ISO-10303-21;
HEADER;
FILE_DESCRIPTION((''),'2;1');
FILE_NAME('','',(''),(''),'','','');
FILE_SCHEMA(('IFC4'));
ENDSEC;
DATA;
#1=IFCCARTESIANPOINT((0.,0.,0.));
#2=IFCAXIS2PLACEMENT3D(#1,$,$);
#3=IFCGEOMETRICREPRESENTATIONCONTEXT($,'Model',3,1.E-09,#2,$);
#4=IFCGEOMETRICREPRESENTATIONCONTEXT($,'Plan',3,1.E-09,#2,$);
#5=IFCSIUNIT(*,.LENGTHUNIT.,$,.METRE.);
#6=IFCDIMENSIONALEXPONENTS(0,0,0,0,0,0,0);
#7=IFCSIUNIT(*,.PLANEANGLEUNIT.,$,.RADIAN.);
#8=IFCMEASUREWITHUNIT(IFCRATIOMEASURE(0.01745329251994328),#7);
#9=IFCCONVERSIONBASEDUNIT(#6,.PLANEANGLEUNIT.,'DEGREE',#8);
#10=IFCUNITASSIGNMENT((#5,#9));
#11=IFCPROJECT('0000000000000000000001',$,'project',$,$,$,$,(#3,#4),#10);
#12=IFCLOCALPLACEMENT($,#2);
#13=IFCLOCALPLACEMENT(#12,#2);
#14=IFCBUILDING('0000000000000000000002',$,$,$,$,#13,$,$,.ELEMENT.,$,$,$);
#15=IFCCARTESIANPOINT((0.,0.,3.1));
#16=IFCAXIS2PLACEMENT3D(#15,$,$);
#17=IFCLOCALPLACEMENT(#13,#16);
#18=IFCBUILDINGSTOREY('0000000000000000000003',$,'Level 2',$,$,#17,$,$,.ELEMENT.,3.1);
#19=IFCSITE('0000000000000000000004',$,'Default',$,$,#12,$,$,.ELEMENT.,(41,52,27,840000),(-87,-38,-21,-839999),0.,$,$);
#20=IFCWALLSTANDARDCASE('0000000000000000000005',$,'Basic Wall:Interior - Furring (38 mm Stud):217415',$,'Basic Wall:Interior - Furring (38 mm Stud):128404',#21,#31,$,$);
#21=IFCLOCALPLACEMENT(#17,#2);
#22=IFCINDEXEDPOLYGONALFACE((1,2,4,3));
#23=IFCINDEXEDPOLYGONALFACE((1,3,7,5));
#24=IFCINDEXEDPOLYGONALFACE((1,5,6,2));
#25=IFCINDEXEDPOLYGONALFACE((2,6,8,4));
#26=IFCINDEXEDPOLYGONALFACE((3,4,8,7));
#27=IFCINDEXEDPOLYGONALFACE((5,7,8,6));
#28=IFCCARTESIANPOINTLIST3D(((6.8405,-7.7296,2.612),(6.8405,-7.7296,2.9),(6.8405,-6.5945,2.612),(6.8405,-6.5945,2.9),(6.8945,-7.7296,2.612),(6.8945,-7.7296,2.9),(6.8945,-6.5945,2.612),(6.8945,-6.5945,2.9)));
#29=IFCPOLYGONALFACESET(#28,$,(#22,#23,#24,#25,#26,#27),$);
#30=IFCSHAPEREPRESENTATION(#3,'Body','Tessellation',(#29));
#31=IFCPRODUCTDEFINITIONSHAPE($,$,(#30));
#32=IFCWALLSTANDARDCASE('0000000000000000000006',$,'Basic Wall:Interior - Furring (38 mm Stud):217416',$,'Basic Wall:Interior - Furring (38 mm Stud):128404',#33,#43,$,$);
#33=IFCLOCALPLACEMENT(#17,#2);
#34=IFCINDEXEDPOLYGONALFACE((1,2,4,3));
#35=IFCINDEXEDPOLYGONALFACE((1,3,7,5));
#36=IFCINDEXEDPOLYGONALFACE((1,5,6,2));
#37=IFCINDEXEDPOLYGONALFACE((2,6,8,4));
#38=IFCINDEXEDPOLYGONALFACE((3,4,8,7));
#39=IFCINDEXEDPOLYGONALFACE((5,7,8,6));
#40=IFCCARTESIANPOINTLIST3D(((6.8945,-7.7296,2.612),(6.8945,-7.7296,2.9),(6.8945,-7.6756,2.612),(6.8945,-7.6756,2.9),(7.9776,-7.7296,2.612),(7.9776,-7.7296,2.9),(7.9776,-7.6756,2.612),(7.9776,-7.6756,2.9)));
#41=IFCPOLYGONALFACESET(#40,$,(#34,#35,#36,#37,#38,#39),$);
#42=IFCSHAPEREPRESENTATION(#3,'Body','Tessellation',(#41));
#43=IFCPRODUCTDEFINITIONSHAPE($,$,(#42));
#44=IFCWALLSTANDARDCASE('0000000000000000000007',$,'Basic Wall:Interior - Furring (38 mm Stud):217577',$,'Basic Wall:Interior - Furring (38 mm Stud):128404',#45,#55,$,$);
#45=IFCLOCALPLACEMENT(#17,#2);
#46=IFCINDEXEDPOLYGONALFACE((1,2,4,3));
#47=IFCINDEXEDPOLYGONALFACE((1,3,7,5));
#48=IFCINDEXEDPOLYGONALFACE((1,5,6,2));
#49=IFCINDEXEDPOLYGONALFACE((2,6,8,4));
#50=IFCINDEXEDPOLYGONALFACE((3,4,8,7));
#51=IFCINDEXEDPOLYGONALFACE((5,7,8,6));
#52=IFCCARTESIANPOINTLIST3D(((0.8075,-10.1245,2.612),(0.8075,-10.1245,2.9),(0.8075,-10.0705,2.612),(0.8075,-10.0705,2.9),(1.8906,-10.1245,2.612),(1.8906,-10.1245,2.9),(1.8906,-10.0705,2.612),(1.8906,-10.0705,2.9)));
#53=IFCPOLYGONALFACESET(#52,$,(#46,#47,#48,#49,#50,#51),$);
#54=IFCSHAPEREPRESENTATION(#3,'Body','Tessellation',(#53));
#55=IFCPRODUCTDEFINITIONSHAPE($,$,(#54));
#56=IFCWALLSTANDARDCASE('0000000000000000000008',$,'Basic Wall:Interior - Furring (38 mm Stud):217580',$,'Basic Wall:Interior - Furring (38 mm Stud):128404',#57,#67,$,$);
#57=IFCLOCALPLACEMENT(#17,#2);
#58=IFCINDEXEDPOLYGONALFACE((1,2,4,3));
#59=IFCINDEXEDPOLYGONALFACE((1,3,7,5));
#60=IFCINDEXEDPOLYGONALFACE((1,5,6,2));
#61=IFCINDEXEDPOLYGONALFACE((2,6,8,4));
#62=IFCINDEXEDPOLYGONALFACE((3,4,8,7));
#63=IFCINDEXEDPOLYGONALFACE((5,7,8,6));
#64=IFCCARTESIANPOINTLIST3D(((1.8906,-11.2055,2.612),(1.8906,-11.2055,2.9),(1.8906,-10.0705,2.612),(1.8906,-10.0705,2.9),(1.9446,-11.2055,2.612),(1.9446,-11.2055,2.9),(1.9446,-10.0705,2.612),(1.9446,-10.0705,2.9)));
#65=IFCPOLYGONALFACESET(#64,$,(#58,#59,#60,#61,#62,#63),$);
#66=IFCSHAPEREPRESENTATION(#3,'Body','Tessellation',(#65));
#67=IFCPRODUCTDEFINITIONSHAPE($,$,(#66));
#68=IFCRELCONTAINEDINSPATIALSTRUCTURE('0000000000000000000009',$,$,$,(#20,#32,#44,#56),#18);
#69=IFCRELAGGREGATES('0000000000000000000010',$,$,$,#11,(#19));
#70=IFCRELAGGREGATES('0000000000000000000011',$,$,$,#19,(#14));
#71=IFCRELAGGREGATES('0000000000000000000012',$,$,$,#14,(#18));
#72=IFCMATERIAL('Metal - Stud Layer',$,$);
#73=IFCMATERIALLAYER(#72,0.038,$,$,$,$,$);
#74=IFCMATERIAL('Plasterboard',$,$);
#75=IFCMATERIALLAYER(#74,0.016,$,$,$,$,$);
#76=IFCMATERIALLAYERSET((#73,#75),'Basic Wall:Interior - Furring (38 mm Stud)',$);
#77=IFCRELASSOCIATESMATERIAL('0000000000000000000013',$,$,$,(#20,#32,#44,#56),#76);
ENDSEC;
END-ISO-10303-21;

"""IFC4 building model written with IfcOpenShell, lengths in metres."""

from ifc_helpers import new_model, entity, si_unit, converted_unit, frame, frame_2d, origin, place, context, project, spatial, rectangle, extrude, material, layer, layer_set, layer_usage, element, save


model = new_model("IFC4")

# Units and contexts
model_context = context("Model", 3, precision=1e-09, world=origin())
plan_context = context("Plan", 3, precision=1e-09, world=origin())
ifc_project = project(units=[si_unit("LENGTHUNIT", "METRE"), converted_unit("PLANEANGLEUNIT", "DEGREE", entity("IfcRatioMeasure", 0.01745329251994328), si_unit("PLANEANGLEUNIT", "RADIAN"), dimensions=[0, 0, 0, 0, 0, 0, 0])], contexts=[model_context, plan_context])

# Site, building, storey
site_placement = place(None, origin())
site = spatial("IfcSite", under=ifc_project, at=site_placement, Name="Default", CompositionType="ELEMENT", RefLatitude=(41, 52, 27, 840000), RefLongitude=(-87, -38, -21, -839999), RefElevation=0.0)
building_placement = place(site_placement, origin())
building = spatial("IfcBuilding", under=site, at=building_placement, CompositionType="ELEMENT")
storey_placement = place(building_placement, frame((0.0, 0.0, 3.1)))
storey = spatial("IfcBuildingStorey", under=building, at=storey_placement, Name="Level 2", CompositionType="ELEMENT", Elevation=3.1)

# Shared definitions
ifc_material_1 = material(Name="Plasterboard")
ifc_material_2 = material(Name="Metal - Stud Layer")

# Walls
ifc_layer_1 = layer(ifc_material_2, 0.038)
ifc_layer_2 = layer(ifc_material_1, 0.016)
ifc_layer_set_1 = layer_set([ifc_layer_1, ifc_layer_2], Name="Basic Wall:Interior - Furring (38 mm Stud)")
ifc_layer_usage_1 = layer_usage(ifc_layer_set_1, "AXIS2", "NEGATIVE", 0.027)
wall_1_placement = place(storey_placement, frame((6.8675, -7.7296, 2.612), z_axis=(0.0, 0.0, 1.0), x_axis=(0.0, 1.0, 0.0)))
element("IfcWallStandardCase", 1, at=wall_1_placement, inside=storey, material=ifc_layer_usage_1, Name="Basic Wall:Interior - Furring (38 mm Stud):217415", ObjectType="Basic Wall:Interior - Furring (38 mm Stud):128404", context=model_context, shape_type="SweptSolid", body=[
    extrude(rectangle(XDim=1.1351, YDim=0.054, at=frame_2d((0.5675, 0.0), x_axis=(-1.0, 0.0))), origin(), (0.0, 0.0, 1.0), 0.288),
])
ifc_layer_usage_2 = layer_usage(ifc_layer_set_1, "AXIS2", "NEGATIVE", 0.027)
wall_2_placement = place(storey_placement, frame((7.9776, -7.7026, 2.612), z_axis=(0.0, 0.0, 1.0), x_axis=(-1.0, 0.0, 0.0)))
element("IfcWallStandardCase", 2, at=wall_2_placement, inside=storey, material=ifc_layer_usage_2, Name="Basic Wall:Interior - Furring (38 mm Stud):217416", ObjectType="Basic Wall:Interior - Furring (38 mm Stud):128404", context=model_context, shape_type="SweptSolid", body=[
    extrude(rectangle(XDim=1.0831, YDim=0.054, at=frame_2d((0.5416, 0.0), x_axis=(-1.0, 0.0))), origin(), (0.0, 0.0, 1.0), 0.288),
])
ifc_layer_usage_3 = layer_usage(ifc_layer_set_1, "AXIS2", "NEGATIVE", 0.027)
wall_3_placement = place(storey_placement, frame((0.8075, -10.0975, 2.612)))
element("IfcWallStandardCase", 3, at=wall_3_placement, inside=storey, material=ifc_layer_usage_3, Name="Basic Wall:Interior - Furring (38 mm Stud):217577", ObjectType="Basic Wall:Interior - Furring (38 mm Stud):128404", context=model_context, shape_type="SweptSolid", body=[
    extrude(rectangle(XDim=1.0831, YDim=0.054, at=frame_2d((0.5415, 0.0), x_axis=(-1.0, 0.0))), origin(), (0.0, 0.0, 1.0), 0.288),
])
ifc_layer_usage_4 = layer_usage(ifc_layer_set_1, "AXIS2", "NEGATIVE", 0.027)
wall_4_placement = place(storey_placement, frame((1.9176, -10.0705, 2.612), z_axis=(0.0, 0.0, 1.0), x_axis=(0.0, -1.0, 0.0)))
element("IfcWallStandardCase", 4, at=wall_4_placement, inside=storey, material=ifc_layer_usage_4, Name="Basic Wall:Interior - Furring (38 mm Stud):217580", ObjectType="Basic Wall:Interior - Furring (38 mm Stud):128404", context=model_context, shape_type="SweptSolid", body=[
    extrude(rectangle(XDim=1.1351, YDim=0.054, at=frame_2d((0.5675, 0.0), x_axis=(-1.0, 0.0))), origin(), (0.0, 0.0, 1.0), 0.288),
])

save(model, "model.ifc")
